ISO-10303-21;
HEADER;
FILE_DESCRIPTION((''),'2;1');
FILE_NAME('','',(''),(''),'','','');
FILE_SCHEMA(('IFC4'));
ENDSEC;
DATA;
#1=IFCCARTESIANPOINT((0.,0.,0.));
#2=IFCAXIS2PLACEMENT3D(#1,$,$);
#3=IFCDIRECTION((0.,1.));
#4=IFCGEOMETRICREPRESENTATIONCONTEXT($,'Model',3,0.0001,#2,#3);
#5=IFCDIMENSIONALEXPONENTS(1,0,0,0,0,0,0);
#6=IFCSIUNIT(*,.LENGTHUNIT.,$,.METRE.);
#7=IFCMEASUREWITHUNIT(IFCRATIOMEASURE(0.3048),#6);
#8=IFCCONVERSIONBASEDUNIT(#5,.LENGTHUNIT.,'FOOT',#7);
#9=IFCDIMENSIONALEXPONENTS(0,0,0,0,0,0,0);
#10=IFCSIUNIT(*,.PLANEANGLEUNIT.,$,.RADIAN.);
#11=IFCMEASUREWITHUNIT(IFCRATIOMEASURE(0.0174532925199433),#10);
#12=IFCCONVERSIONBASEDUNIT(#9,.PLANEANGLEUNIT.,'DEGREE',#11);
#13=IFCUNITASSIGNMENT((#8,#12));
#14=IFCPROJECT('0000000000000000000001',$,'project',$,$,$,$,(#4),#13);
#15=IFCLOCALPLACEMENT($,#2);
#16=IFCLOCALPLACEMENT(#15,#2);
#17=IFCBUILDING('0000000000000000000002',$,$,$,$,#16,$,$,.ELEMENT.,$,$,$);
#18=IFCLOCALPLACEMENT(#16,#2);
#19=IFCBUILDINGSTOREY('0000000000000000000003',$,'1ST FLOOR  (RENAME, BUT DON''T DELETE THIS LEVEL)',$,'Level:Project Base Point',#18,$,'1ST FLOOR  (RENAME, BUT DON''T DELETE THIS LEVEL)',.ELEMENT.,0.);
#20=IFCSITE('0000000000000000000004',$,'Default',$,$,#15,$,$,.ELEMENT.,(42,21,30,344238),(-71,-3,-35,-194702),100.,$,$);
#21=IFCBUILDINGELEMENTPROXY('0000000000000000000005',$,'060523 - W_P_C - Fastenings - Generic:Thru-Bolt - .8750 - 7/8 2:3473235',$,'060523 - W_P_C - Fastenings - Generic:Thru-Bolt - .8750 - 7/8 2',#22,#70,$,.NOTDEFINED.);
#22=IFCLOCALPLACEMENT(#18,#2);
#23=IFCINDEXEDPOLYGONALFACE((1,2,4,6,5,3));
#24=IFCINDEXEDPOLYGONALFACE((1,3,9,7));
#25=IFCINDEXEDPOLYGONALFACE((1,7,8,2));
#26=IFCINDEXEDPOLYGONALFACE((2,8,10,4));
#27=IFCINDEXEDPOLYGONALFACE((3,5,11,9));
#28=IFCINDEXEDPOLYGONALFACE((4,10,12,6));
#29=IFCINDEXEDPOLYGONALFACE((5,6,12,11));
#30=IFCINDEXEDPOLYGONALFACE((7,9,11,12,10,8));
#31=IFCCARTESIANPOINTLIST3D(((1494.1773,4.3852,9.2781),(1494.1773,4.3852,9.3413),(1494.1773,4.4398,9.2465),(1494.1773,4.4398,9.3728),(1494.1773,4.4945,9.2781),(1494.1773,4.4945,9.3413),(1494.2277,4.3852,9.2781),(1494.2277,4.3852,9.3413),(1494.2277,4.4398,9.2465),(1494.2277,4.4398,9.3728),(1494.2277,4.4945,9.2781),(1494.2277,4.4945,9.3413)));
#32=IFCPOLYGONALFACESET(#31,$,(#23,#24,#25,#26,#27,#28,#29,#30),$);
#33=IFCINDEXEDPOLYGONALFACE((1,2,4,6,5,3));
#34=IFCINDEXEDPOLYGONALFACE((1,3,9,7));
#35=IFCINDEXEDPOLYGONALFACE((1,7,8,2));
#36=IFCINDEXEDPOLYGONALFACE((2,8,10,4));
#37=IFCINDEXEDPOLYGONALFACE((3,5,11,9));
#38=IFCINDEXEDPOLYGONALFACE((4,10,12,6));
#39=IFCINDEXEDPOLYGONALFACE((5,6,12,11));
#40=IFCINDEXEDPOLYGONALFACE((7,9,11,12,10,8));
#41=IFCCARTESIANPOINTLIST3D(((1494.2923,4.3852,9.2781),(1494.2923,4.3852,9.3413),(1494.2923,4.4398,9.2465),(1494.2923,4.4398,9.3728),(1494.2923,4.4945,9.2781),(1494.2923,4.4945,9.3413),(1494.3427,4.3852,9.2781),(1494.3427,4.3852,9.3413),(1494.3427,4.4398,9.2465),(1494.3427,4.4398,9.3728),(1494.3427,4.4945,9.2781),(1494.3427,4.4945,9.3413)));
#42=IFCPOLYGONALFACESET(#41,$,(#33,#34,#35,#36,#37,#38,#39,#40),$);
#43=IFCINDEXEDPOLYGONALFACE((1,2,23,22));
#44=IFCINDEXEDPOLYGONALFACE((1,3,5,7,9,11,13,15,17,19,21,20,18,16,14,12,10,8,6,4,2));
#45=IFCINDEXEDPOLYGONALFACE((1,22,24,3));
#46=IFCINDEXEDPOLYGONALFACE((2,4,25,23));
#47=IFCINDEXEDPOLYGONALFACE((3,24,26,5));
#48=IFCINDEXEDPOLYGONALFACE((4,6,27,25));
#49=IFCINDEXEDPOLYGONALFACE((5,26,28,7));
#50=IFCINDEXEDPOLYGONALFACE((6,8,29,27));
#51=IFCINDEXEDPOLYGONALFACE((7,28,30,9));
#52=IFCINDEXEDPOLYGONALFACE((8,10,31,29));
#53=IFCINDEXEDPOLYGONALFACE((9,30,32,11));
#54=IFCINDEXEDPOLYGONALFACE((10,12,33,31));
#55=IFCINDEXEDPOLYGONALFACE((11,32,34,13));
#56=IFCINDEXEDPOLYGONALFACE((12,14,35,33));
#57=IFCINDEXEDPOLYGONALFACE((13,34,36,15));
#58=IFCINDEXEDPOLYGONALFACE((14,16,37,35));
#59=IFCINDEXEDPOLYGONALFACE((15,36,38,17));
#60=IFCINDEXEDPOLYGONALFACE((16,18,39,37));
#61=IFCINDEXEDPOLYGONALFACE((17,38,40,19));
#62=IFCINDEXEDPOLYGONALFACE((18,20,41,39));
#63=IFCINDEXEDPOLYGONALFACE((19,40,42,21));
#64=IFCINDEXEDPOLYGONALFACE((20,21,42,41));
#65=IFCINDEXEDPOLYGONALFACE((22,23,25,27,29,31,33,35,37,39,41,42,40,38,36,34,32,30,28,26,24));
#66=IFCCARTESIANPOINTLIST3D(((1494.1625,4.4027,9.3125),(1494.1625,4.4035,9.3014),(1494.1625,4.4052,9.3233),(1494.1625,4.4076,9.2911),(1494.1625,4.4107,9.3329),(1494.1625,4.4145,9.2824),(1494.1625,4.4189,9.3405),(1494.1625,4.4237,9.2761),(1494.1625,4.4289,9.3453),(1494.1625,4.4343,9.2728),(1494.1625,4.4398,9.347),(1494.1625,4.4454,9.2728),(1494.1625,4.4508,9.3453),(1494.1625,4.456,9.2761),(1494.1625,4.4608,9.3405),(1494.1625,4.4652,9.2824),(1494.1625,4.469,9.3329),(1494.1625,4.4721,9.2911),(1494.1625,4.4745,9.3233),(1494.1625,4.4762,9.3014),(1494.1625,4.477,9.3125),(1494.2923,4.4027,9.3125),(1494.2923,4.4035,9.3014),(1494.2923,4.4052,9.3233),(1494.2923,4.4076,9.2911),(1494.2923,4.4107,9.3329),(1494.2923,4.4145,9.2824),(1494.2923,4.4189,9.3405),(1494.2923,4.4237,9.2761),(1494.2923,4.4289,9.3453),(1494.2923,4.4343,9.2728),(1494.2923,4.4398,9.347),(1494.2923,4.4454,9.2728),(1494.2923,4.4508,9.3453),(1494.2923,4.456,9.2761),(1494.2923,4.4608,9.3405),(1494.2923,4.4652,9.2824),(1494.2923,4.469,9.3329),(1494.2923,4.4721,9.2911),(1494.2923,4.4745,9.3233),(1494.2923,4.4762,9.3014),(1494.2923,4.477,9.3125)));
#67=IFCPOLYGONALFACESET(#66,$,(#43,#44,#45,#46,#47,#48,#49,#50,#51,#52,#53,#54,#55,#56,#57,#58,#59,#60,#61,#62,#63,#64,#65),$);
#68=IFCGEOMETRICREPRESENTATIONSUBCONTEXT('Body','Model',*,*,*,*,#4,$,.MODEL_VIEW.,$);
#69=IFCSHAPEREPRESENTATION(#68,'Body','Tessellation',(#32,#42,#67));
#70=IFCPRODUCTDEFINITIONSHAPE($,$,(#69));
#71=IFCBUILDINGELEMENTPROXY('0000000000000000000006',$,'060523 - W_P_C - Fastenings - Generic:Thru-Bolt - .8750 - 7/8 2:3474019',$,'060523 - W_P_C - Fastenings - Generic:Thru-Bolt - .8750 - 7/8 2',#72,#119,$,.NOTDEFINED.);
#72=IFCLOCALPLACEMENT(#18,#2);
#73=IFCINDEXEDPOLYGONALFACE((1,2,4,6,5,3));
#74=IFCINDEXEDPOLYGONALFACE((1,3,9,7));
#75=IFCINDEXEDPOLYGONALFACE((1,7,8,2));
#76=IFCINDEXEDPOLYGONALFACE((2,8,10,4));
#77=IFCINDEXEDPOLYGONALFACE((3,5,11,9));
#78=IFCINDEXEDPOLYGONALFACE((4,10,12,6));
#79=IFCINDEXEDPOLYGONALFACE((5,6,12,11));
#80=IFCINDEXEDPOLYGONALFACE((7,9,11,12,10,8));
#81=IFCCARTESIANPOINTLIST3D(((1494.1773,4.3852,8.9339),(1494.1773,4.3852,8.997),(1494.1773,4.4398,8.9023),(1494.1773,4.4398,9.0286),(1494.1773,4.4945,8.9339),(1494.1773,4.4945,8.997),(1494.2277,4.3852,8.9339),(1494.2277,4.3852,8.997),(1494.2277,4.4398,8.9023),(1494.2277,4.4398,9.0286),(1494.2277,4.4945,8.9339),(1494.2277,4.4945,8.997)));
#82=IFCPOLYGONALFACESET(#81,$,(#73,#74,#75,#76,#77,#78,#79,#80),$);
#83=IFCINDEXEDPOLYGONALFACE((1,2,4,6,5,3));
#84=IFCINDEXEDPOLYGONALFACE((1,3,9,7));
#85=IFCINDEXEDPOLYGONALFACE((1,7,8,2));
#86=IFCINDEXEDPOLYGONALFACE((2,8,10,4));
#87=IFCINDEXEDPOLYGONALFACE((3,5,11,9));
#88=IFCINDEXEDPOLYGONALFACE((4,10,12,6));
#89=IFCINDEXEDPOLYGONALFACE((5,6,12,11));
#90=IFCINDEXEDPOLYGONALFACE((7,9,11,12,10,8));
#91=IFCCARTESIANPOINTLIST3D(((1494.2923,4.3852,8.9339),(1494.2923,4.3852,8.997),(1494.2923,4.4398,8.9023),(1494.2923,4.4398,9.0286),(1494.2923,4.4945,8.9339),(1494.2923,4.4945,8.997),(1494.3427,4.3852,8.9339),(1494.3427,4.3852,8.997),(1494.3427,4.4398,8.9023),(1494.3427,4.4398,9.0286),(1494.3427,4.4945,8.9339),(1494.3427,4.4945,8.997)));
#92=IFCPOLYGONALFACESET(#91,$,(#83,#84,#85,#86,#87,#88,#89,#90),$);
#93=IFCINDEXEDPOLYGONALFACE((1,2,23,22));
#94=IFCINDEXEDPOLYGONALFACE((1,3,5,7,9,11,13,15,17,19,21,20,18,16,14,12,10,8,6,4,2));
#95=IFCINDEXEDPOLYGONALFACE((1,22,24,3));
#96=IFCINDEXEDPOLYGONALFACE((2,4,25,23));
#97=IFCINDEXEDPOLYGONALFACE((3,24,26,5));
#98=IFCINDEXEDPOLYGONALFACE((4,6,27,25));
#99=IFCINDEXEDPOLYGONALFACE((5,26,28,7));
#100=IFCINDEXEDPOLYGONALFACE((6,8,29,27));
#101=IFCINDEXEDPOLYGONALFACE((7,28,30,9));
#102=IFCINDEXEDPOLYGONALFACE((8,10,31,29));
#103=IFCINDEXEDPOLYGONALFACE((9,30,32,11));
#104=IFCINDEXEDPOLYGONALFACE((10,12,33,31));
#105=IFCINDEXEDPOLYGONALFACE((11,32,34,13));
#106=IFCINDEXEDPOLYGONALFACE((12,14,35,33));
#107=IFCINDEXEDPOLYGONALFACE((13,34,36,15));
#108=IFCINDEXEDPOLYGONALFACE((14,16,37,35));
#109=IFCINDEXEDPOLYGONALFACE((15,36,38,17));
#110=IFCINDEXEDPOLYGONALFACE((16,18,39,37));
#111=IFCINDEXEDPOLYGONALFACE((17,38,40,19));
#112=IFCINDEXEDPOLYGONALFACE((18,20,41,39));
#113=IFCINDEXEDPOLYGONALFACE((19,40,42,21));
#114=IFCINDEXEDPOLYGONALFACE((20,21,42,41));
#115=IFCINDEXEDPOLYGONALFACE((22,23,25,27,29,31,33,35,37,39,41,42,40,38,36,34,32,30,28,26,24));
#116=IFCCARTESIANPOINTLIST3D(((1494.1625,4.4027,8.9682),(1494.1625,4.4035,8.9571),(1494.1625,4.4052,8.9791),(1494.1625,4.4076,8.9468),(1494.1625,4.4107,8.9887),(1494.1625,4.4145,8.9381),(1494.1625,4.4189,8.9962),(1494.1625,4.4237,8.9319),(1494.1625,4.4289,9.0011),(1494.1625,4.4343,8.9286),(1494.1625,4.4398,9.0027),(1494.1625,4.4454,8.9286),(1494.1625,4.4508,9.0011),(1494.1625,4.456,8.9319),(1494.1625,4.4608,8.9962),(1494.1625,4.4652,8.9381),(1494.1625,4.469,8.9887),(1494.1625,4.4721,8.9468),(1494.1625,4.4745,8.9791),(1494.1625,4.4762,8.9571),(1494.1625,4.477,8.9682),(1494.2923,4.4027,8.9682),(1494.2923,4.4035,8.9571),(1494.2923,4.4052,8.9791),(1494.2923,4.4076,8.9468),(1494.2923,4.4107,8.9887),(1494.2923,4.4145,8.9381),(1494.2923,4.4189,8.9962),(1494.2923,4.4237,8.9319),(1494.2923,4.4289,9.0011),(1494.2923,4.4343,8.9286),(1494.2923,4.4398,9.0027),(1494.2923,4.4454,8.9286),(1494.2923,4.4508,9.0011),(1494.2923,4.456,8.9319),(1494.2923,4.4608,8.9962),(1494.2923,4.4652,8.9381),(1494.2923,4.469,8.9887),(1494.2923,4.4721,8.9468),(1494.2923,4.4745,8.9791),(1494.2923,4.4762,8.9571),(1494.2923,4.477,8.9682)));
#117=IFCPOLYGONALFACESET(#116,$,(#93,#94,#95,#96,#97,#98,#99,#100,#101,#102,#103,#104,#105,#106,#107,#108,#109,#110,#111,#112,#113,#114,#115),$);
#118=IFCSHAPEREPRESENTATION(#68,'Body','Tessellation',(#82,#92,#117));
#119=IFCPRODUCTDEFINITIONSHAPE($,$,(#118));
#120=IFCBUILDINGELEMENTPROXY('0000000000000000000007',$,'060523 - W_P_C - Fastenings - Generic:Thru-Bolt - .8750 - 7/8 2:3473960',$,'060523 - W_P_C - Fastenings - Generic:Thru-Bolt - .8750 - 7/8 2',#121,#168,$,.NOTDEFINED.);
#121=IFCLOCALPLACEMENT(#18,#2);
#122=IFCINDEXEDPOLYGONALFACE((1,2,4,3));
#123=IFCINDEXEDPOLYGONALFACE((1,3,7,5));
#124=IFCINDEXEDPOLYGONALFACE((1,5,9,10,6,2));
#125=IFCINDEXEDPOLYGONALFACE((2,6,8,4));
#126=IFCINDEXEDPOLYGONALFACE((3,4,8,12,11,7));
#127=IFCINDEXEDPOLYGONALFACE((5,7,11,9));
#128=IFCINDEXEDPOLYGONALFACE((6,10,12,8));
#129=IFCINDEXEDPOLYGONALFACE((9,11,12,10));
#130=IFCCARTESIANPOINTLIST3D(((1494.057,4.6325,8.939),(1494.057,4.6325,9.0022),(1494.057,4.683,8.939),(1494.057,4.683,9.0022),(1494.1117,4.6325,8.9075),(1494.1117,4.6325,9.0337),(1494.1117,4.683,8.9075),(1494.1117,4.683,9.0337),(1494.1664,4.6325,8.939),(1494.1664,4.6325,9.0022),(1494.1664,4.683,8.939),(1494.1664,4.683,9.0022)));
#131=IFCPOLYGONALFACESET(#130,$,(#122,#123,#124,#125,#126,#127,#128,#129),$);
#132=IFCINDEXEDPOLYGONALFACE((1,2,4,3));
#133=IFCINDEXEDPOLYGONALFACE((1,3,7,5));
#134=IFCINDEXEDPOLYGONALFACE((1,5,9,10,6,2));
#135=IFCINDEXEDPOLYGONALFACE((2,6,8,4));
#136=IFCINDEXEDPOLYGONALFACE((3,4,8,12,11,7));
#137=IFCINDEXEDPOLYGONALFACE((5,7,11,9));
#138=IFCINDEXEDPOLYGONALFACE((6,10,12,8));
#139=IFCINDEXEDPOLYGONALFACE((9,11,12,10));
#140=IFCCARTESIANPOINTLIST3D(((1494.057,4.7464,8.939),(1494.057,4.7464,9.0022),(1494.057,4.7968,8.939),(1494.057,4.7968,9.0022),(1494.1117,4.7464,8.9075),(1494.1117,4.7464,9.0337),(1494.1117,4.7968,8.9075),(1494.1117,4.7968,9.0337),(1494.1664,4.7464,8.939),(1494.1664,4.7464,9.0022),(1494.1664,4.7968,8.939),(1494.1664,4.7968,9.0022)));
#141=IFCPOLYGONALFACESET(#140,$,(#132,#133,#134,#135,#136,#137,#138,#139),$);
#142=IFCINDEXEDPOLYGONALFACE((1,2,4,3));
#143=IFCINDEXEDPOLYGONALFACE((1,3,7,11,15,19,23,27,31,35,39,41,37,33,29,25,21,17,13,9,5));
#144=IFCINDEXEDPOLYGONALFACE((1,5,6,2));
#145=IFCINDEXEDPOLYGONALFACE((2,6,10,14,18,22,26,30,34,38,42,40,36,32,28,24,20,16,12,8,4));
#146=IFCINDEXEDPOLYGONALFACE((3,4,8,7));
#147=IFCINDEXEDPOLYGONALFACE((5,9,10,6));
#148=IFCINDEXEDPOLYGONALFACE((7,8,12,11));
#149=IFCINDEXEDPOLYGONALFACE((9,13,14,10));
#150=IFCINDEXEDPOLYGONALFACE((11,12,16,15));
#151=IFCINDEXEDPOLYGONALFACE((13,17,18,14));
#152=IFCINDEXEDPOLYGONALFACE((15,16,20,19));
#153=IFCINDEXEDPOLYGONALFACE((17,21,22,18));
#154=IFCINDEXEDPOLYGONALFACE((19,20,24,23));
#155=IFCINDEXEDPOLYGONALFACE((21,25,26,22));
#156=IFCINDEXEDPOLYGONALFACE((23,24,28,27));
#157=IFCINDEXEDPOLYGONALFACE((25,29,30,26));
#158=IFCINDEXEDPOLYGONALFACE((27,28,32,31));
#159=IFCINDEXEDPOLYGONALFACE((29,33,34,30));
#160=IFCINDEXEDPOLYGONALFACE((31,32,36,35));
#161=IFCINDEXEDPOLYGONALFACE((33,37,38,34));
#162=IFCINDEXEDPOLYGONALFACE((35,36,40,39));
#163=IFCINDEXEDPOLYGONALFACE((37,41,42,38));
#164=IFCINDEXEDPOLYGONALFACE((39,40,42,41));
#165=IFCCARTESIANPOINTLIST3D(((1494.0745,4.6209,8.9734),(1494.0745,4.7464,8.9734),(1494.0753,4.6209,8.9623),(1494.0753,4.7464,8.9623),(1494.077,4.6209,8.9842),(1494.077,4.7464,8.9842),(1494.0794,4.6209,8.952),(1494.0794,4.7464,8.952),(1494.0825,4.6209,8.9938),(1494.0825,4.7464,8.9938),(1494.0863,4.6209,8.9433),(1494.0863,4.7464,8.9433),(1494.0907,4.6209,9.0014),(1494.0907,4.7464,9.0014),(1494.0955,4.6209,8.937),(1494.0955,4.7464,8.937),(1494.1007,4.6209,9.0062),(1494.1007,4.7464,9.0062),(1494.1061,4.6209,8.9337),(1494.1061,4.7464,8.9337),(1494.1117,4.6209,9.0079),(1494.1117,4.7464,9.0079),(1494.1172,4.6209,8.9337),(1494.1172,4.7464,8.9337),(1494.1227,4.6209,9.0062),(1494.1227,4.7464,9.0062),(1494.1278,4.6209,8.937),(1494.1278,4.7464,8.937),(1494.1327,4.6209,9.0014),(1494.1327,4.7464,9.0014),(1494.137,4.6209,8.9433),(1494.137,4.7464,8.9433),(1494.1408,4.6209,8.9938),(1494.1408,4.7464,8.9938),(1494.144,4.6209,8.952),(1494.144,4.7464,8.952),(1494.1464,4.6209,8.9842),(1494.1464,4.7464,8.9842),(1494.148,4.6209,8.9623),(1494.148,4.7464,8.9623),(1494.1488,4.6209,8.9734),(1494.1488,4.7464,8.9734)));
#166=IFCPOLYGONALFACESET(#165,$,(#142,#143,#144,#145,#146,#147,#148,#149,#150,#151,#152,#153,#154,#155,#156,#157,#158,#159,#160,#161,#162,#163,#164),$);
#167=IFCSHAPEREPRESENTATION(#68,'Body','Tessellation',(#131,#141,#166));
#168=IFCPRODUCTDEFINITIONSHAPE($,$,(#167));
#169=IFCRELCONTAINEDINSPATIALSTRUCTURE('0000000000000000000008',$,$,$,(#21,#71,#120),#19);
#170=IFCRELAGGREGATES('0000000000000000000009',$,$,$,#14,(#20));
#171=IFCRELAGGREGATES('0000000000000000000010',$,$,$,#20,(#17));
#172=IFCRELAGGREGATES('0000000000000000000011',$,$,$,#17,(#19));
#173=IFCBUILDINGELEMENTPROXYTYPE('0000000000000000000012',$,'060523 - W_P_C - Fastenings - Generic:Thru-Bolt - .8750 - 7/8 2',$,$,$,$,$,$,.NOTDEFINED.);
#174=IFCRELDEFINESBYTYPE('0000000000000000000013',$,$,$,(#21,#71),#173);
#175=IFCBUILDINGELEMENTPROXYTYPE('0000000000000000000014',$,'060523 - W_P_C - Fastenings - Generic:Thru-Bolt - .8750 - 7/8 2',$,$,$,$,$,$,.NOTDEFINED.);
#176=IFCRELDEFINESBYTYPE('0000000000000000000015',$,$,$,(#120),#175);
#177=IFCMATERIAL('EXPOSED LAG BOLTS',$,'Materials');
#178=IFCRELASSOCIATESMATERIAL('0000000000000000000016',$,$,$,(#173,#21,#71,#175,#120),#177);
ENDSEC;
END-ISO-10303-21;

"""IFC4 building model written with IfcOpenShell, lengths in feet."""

from ifc_helpers import new_model, entity, si_unit, converted_unit, direction, frame, frame_2d, origin, place, context, subcontext, project, spatial, polyline, circle, outline, extrude, source, transform, mapped, material, type_object, type_shapes, element, save


model = new_model("IFC4")

# Units and contexts
model_context = context("Model", 3, precision=0.0001, world=origin(), true_north=direction((0.0, 1.0)))
body_context = subcontext(model_context, "Body", "Model", "MODEL_VIEW")
ifc_project = project(units=[converted_unit("LENGTHUNIT", "FOOT", entity("IfcRatioMeasure", 0.3048), si_unit("LENGTHUNIT", "METRE"), dimensions=[1, 0, 0, 0, 0, 0, 0]), converted_unit("PLANEANGLEUNIT", "DEGREE", entity("IfcRatioMeasure", 0.0174532925199433), si_unit("PLANEANGLEUNIT", "RADIAN"), dimensions=[0, 0, 0, 0, 0, 0, 0])], contexts=[model_context])

# Site, building, storey
site_placement = place(None, origin())
site = spatial("IfcSite", under=ifc_project, at=site_placement, Name="Default", CompositionType="ELEMENT", RefLatitude=(42, 21, 30, 344238), RefLongitude=(-71, -3, -35, -194702), RefElevation=100.0)
building_placement = place(site_placement, origin())
building = spatial("IfcBuilding", under=site, at=building_placement, CompositionType="ELEMENT")
storey_placement = place(building_placement, origin())
storey = spatial("IfcBuildingStorey", under=building, at=storey_placement, Name="1ST FLOOR  (RENAME, BUT DON'T DELETE THIS LEVEL)", ObjectType="Level:Project Base Point", LongName="1ST FLOOR  (RENAME, BUT DON'T DELETE THIS LEVEL)", CompositionType="ELEMENT", Elevation=0.0)

# Building element proxies
ifc_material_1 = material(Name="EXPOSED LAG BOLTS", Category="Materials")
building_element_proxy_type_1 = type_object("IfcBuildingElementProxyType", Name="060523 - W_P_C - Fastenings - Generic:Thru-Bolt - .8750 - 7/8 2", PredefinedType="NOTDEFINED", material=ifc_material_1)
shared_shape_1 = source(origin(), body_context, "Body", "SweptSolid", [
    extrude(outline(polyline([(-0.0316, -0.0547), (0.0316, -0.0547), (0.0631, 0.0), (0.0316, 0.0547), (-0.0316, 0.0547), (-0.0631, 0.0), (-0.0316, -0.0547)])), frame((0.0, 0.0, -0.115), z_axis=(0.0, 0.0, 1.0), x_axis=(0.866025, -0.5, 0.0)), (0.0, 0.0, 1.0), 0.0505),
    extrude(outline(polyline([(-0.0316, -0.0547), (0.0316, -0.0547), (0.0631, 0.0), (0.0316, 0.0547), (-0.0316, 0.0547), (-0.0631, 0.0), (-0.0316, -0.0547)])), frame((0.0, 0.0, 0.0), z_axis=(0.0, 0.0, 1.0), x_axis=(0.0, -1.0, 0.0)), (0.0, 0.0, 1.0), 0.0505),
    extrude(circle(Radius=0.0373, at=frame_2d((0.0, 0.0), x_axis=(1.0, 0.0))), frame((0.0, 0.0, -0.1298), z_axis=(0.0, 0.0, 1.0), x_axis=(0.0, 1.0, 0.0)), (0.0, 0.0, 1.0), 0.1298),
])
type_shapes(building_element_proxy_type_1, [shared_shape_1])
for number, where, z_axis, x_axis, name in (
    (1, (1494.2923, 4.4398, 9.3097), (1.0, 0.0, 0.0), (0.0, 1.0, 0.0), "060523 - W_P_C - Fastenings - Generic:Thru-Bolt - .8750 - 7/8 2:3473235"),
    (2, (1494.2923, 4.4398, 8.9654), (1.0, 0.0, 0.0), (0.0, 1.0, 0.0), "060523 - W_P_C - Fastenings - Generic:Thru-Bolt - .8750 - 7/8 2:3474019"),
):
    element("IfcBuildingElementProxy", number, at=place(storey_placement, frame(where, z_axis=z_axis, x_axis=x_axis)), inside=storey, type_object=building_element_proxy_type_1, material=ifc_material_1, Name=name, ObjectType="060523 - W_P_C - Fastenings - Generic:Thru-Bolt - .8750 - 7/8 2", PredefinedType="NOTDEFINED", context=body_context, shape_type="MappedRepresentation", body=[
        mapped(shared_shape_1, transform((0.0, 0.0, 0.0), scale=1.0)),
    ])
building_element_proxy_type_2 = type_object("IfcBuildingElementProxyType", Name="060523 - W_P_C - Fastenings - Generic:Thru-Bolt - .8750 - 7/8 2", PredefinedType="NOTDEFINED", material=ifc_material_1)
shared_shape_2 = source(origin(), body_context, "Body", "SweptSolid", [
    extrude(outline(polyline([(-0.0316, -0.0547), (0.0316, -0.0547), (0.0631, 0.0), (0.0316, 0.0547), (-0.0316, 0.0547), (-0.0631, 0.0), (-0.0316, -0.0547)])), frame((0.0, 0.0, -0.1139), z_axis=(0.0, 0.0, 1.0), x_axis=(0.866025, -0.5, 0.0)), (0.0, 0.0, 1.0), 0.0505),
    extrude(outline(polyline([(-0.0316, -0.0547), (0.0316, -0.0547), (0.0631, 0.0), (0.0316, 0.0547), (-0.0316, 0.0547), (-0.0631, 0.0), (-0.0316, -0.0547)])), frame((0.0, 0.0, 0.0), z_axis=(0.0, 0.0, 1.0), x_axis=(0.0, -1.0, 0.0)), (0.0, 0.0, 1.0), 0.0505),
    extrude(circle(Radius=0.0373, at=frame_2d((0.0, 0.0), x_axis=(1.0, 0.0))), frame((0.0, 0.0, -0.1255), z_axis=(0.0, 0.0, 1.0), x_axis=(0.0, 1.0, 0.0)), (0.0, 0.0, 1.0), 0.1255),
])
type_shapes(building_element_proxy_type_2, [shared_shape_2])
proxy_1_placement = place(storey_placement, frame((1494.1117, 4.7464, 8.9706), z_axis=(0.0, 1.0, 0.0), x_axis=(-1.0, 0.0, 0.0)))
element("IfcBuildingElementProxy", 3, at=proxy_1_placement, inside=storey, type_object=building_element_proxy_type_2, material=ifc_material_1, Name="060523 - W_P_C - Fastenings - Generic:Thru-Bolt - .8750 - 7/8 2:3473960", ObjectType="060523 - W_P_C - Fastenings - Generic:Thru-Bolt - .8750 - 7/8 2", PredefinedType="NOTDEFINED", context=body_context, shape_type="MappedRepresentation", body=[
    mapped(shared_shape_2, transform((0.0, 0.0, 0.0), scale=1.0)),
])

save(model, "model.ifc")
